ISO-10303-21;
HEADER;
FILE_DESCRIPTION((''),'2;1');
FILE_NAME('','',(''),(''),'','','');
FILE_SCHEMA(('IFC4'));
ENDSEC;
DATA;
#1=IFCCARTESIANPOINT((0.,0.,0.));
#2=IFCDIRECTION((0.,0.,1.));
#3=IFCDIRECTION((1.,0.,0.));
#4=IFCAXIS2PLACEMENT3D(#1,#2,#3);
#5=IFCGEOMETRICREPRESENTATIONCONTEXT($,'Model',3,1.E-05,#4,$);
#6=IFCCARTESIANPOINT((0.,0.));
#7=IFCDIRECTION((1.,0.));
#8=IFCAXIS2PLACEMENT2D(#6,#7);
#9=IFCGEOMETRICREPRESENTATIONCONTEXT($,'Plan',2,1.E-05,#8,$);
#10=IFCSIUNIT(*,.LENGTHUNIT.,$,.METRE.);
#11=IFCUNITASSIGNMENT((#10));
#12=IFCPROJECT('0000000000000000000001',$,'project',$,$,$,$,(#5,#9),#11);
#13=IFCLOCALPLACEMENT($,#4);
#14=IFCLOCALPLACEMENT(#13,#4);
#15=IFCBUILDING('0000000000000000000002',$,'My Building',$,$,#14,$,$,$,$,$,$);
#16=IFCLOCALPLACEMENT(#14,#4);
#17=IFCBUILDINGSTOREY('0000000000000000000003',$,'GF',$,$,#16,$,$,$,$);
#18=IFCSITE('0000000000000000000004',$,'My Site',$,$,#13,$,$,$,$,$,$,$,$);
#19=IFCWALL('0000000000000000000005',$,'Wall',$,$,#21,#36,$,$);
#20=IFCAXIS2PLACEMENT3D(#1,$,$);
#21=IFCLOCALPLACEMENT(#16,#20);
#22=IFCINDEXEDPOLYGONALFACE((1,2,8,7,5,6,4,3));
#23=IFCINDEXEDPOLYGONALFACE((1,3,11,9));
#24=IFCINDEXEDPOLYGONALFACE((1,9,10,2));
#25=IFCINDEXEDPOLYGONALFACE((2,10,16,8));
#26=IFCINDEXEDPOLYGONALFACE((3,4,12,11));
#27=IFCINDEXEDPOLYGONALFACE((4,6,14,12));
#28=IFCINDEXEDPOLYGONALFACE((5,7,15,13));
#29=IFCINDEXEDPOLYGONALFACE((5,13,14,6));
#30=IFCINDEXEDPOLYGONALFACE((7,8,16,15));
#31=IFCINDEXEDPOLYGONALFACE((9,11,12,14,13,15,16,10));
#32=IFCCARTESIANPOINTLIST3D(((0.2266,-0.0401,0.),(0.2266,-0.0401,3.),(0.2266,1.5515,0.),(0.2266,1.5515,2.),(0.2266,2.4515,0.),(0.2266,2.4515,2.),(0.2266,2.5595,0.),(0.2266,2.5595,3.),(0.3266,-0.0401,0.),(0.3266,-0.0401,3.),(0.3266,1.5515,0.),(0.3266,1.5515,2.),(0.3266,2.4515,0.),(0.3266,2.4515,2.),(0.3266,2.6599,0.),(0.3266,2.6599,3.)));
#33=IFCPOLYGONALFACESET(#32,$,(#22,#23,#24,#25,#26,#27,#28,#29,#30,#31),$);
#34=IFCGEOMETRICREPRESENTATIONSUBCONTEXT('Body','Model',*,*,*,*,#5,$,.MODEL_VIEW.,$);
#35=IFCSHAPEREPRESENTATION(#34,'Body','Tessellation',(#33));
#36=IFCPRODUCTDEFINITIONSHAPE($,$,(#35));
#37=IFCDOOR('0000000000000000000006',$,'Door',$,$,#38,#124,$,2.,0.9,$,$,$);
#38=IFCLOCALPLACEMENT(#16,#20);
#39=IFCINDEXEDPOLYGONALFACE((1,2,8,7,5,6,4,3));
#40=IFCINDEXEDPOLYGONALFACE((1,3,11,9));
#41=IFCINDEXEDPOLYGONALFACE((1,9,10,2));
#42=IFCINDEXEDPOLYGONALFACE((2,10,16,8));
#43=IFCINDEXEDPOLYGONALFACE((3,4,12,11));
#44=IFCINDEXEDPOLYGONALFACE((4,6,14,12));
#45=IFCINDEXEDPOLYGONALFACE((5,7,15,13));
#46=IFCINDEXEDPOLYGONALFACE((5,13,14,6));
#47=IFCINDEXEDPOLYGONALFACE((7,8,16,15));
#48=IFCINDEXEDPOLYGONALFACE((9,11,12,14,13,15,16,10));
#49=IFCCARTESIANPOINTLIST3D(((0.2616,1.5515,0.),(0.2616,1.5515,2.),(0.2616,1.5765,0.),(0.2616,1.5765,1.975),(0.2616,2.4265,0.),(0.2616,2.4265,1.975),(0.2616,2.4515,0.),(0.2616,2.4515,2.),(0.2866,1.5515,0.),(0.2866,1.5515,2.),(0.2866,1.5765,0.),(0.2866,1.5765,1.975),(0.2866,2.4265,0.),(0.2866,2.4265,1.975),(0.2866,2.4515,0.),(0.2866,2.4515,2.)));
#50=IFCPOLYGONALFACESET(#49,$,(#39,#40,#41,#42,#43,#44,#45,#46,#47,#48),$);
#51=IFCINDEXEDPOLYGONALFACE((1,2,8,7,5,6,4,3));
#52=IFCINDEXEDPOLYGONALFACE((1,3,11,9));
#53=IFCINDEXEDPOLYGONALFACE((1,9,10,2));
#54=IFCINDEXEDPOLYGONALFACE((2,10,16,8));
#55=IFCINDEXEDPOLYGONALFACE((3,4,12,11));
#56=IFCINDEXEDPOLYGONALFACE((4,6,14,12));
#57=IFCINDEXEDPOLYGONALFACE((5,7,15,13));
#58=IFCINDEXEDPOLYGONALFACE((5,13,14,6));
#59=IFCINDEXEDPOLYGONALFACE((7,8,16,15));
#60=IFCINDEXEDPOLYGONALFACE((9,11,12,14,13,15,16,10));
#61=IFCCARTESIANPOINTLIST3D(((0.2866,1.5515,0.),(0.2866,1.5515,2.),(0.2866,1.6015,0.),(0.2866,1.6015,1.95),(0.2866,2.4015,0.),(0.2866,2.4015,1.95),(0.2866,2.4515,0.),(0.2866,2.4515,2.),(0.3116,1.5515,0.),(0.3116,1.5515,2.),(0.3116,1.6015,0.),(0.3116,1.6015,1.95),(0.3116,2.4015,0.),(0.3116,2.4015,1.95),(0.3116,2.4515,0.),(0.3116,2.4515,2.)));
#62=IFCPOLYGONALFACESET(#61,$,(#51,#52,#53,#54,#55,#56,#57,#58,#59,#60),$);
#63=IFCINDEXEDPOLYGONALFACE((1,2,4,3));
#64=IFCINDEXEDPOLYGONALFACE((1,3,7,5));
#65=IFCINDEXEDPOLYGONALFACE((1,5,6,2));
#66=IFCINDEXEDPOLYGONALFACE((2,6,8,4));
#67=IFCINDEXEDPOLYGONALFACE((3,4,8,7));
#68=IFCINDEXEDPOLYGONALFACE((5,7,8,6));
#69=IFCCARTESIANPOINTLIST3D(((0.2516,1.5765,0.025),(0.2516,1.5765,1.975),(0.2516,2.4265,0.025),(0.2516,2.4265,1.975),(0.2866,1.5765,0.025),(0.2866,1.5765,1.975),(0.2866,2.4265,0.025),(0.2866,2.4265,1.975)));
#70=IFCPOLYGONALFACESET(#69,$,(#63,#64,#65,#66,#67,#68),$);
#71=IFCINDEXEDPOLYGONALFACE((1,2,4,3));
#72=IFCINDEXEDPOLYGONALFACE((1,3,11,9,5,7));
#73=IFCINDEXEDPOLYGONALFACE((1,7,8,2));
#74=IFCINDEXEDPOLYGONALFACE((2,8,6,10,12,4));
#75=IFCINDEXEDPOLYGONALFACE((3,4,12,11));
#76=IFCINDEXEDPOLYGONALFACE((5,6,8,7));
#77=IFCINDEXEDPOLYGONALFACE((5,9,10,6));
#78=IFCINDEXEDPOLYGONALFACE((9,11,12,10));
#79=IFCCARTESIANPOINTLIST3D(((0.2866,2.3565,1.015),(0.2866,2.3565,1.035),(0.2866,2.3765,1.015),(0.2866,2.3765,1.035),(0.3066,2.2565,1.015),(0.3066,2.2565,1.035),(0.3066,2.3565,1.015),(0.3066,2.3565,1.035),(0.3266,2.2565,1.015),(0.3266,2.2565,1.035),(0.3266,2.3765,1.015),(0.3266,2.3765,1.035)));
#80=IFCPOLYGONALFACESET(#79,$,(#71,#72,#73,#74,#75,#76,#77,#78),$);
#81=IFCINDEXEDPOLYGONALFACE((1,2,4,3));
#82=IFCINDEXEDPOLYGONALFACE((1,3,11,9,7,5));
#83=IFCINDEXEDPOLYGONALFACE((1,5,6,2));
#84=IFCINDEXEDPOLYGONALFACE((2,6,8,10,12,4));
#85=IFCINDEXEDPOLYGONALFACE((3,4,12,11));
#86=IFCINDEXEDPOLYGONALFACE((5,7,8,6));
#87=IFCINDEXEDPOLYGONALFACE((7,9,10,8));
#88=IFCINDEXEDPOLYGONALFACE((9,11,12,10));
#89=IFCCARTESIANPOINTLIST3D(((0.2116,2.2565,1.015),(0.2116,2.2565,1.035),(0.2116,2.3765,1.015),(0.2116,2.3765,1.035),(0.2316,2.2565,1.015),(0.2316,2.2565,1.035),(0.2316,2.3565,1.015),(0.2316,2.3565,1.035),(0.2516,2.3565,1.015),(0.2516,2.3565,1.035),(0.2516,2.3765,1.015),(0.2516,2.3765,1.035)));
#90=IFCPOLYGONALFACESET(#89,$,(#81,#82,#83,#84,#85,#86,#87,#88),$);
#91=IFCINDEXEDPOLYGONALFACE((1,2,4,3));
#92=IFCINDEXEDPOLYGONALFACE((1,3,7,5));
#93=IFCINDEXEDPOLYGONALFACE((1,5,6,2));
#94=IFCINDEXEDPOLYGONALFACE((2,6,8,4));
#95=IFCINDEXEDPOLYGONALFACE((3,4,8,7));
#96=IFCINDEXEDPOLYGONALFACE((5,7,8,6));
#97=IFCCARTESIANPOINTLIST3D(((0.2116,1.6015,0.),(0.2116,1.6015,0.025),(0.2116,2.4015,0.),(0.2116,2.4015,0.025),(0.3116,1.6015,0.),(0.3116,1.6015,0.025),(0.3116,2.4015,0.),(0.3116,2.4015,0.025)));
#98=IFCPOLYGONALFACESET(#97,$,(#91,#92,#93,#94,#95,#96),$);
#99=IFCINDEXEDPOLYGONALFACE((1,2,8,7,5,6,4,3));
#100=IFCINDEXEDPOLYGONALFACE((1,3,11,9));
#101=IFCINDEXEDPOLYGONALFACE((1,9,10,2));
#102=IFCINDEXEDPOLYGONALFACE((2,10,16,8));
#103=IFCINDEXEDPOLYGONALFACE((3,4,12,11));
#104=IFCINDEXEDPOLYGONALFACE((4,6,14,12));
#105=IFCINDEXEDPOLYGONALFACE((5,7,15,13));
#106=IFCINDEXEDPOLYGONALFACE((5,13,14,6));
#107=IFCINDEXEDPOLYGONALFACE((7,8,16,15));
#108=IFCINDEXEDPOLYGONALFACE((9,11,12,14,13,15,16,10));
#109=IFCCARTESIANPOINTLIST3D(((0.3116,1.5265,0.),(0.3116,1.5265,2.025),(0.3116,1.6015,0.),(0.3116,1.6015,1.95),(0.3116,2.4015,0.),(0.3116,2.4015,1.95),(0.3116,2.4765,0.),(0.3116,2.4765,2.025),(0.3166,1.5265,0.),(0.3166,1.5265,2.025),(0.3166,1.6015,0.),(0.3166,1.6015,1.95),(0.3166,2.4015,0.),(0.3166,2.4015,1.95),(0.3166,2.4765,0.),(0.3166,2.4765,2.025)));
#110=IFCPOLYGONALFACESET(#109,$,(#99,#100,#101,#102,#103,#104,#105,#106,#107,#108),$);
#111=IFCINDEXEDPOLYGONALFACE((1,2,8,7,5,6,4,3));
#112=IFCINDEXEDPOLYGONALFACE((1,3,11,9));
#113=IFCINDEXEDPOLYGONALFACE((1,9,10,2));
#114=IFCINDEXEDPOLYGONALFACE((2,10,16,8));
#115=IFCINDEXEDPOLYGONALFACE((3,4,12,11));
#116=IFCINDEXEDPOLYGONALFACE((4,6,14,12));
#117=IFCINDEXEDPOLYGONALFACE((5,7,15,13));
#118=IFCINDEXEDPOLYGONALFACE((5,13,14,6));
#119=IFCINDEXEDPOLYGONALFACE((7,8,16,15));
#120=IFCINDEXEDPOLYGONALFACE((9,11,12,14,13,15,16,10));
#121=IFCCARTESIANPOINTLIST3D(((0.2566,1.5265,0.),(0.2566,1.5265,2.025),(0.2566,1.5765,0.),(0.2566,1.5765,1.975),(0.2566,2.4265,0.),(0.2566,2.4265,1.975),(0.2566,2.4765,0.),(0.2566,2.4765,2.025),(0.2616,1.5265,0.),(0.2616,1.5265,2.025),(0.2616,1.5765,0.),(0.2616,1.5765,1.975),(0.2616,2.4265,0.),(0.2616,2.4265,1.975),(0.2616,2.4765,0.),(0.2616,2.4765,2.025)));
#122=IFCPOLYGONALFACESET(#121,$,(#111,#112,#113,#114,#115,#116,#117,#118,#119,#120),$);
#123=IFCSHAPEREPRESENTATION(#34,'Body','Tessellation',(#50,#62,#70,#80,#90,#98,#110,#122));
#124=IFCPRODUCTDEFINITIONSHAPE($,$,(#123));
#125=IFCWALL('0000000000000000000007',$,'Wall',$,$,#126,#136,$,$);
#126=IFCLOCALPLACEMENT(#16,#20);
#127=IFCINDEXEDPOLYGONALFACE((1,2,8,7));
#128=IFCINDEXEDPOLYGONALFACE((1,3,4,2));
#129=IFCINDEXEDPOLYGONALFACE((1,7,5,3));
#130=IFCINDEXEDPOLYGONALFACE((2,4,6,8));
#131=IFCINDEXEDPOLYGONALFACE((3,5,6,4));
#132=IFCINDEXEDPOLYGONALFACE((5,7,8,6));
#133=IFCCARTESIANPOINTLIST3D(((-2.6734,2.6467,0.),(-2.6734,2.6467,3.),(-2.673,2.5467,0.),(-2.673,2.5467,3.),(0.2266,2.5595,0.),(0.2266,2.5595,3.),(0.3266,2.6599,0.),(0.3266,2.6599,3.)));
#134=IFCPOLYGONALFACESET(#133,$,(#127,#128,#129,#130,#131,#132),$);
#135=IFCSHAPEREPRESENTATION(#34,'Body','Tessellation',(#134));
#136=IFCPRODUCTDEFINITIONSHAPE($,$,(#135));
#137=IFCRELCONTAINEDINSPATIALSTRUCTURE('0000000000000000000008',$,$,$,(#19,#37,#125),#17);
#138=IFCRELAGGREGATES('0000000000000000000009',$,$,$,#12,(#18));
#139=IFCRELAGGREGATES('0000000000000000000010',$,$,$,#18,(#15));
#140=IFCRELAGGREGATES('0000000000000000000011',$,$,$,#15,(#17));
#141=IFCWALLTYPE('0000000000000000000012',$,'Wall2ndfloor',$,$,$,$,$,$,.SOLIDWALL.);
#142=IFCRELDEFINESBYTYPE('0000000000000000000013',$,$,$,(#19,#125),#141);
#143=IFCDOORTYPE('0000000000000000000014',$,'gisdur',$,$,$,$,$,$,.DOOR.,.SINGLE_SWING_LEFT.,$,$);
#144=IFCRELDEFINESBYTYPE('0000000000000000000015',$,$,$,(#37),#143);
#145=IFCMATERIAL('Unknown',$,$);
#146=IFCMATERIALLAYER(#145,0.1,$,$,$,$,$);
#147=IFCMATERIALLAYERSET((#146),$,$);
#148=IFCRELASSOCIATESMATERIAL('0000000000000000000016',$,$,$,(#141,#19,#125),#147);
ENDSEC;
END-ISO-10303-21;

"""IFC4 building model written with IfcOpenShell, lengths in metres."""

from ifc_helpers import new_model, entity, si_unit, frame, origin_with_axes, origin_2d_with_axis, place, context, subcontext, project, spatial, line, indexed_curve, outline, extrude, shape, source, transform, mapped, material, layer, layer_set, layer_usage, type_object, type_shapes, element, fill, save


model = new_model("IFC4")

# Units and contexts
model_context = context("Model", 3, precision=1e-05, world=origin_with_axes())
plan_context = context("Plan", 2, precision=1e-05, world=origin_2d_with_axis())
body_context_1 = subcontext(model_context, "Body", "Model", "MODEL_VIEW")
body_context_2 = subcontext(plan_context, "Body", "Plan", "PLAN_VIEW")
ifc_project = project(units=[si_unit("LENGTHUNIT", "METRE")], contexts=[model_context, plan_context])

# Site, building, storey
site_placement = place(None, origin_with_axes())
site = spatial("IfcSite", under=ifc_project, at=site_placement, Name="My Site")
building_placement = place(site_placement, origin_with_axes())
building = spatial("IfcBuilding", under=site, at=building_placement, Name="My Building")
storey_placement = place(building_placement, origin_with_axes())
storey = spatial("IfcBuildingStorey", under=building, at=storey_placement, Name="GF")

# Shared definitions
ifc_material = material(Name="Unknown")

# Shared definitions
ifc_layer_1 = layer(ifc_material, 0.1)
ifc_layer_set_1 = layer_set([ifc_layer_1])
wall_type = type_object("IfcWallType", Name="Wall2ndfloor", PredefinedType="SOLIDWALL", material=ifc_layer_set_1)

# Wall, opening, door
ifc_layer_usage_1 = layer_usage(ifc_layer_set_1, "AXIS2", "POSITIVE", 0.0)
wall_1_placement = place(storey_placement, frame((0.3266, -0.0401, 0.0), z_axis=(0.0, 0.0, 1.0), x_axis=(0.0, 1.0, 0.0)))
wall_1 = element("IfcWall", 1, at=wall_1_placement, inside=storey, type_object=wall_type, material=ifc_layer_usage_1, Name="Wall", context=body_context_1, shape_type="SweptSolid", body=[
    extrude(outline(indexed_curve([(0.0, 0.0), (0.0, 0.1), (2.5996, 0.1), (2.7, 0.0)], segments=[line(1, 2, 3, 4, 1)])), origin_with_axes(), (0.0, 0.0, 1.0), 3.0),
])
shared_shape_1 = source(origin_with_axes(), body_context_1, "Body", "SweptSolid", [
    extrude(outline(indexed_curve([(0.0, 0.0), (0.9, 0.0), (0.9, 2.0), (0.0, 2.0)], segments=[line(1, 2, 3, 4, 1)])), frame((0.0, -0.6, 0.0), z_axis=(0.0, -1.0, 0.0), x_axis=(1.0, 0.0, 0.0)), (0.0, 0.0, -1.0), 1.2),
])
opening_1_placement = place(wall_1_placement, frame((1.5916, 0.015, 0.0), z_axis=(0.0, 0.0, 1.0), x_axis=(1.0, 0.0, 0.0)))
opening_1 = element("IfcOpeningElement", 2, at=opening_1_placement, cuts=wall_1, PredefinedType="OPENING", context=body_context_1, shape_type="MappedRepresentation", body=[
    mapped(shared_shape_1, transform((0.0, 0.0, 0.0), x_axis=(1.0, 0.0, 0.0), y_axis=(0.0, 1.0, 0.0), z_axis=(0.0, 0.0, 1.0), scale=1.0)),
])
door_type_1 = type_object("IfcDoorType", Name="gisdur", OperationType="SINGLE_SWING_LEFT", PredefinedType="DOOR")
shared_shape_2 = source(origin_with_axes(), body_context_1, "Body", "SweptSolid", [
    extrude(outline(indexed_curve([(0.0, 0.0), (0.0, 2.0), (0.9, 2.0), (0.9, 0.0), (0.875, 0.0), (0.875, 1.975), (0.025, 1.975), (0.025, 0.0)], segments=[line(1, 2, 3, 4, 5, 6, 7, 8, 1)])), frame((0.0, 0.025, 0.0), z_axis=(0.0, -1.0, 0.0), x_axis=(1.0, 0.0, 0.0)), (0.0, 0.0, -1.0), 0.025),
    extrude(outline(indexed_curve([(0.0, 0.0), (0.0, 2.0), (0.9, 2.0), (0.9, 0.0), (0.85, 0.0), (0.85, 1.95), (0.05, 1.95), (0.05, 0.0)], segments=[line(1, 2, 3, 4, 5, 6, 7, 8, 1)])), frame((0.0, 0.0, 0.0), z_axis=(0.0, -1.0, 0.0), x_axis=(1.0, 0.0, 0.0)), (0.0, 0.0, -1.0), 0.025),
    extrude(outline(indexed_curve([(0.0, 0.0), (0.85, 0.0), (0.85, 0.035), (0.0, 0.035)], segments=[line(1, 2, 3, 4, 1)])), frame((0.025, 0.025, 0.025), z_axis=(0.0, 0.0, 1.0), x_axis=(1.0, 0.0, 0.0)), (0.0, 0.0, 1.0), 1.95),
    extrude(outline(indexed_curve([(0.0, 0.0), (0.0, -0.04), (-0.12, -0.04), (-0.12, -0.02), (-0.02, -0.02), (-0.02, 0.0)], segments=[line(1, 2, 3, 4, 5, 6, 1)])), frame((0.825, 0.025, 1.015), z_axis=(0.0, 0.0, 1.0), x_axis=(1.0, 0.0, 0.0)), (0.0, 0.0, 1.0), 0.02),
    extrude(outline(indexed_curve([(0.0, 0.0), (0.0, 0.04), (-0.12, 0.04), (-0.12, 0.02), (-0.02, 0.02), (-0.02, 0.0)], segments=[line(1, 2, 3, 4, 5, 6, 1)])), frame((0.825, 0.06, 1.015), z_axis=(0.0, 0.0, 1.0), x_axis=(1.0, 0.0, 0.0)), (0.0, 0.0, 1.0), 0.02),
    extrude(outline(indexed_curve([(0.0, 0.0), (0.8, 0.0), (0.8, 0.1), (0.0, 0.1)], segments=[line(1, 2, 3, 4, 1)])), frame((0.05, 0.0, 0.0), z_axis=(0.0, 0.0, 1.0), x_axis=(1.0, 0.0, 0.0)), (0.0, 0.0, 1.0), 0.025),
    extrude(outline(indexed_curve([(0.0, 0.0), (0.0, 2.025), (0.95, 2.025), (0.95, 0.0), (0.875, 0.0), (0.875, 1.95), (0.075, 1.95), (0.075, 0.0)], segments=[line(1, 2, 3, 4, 5, 6, 7, 8, 1)])), frame((-0.025, -0.005, 0.0), z_axis=(0.0, -1.0, 0.0), x_axis=(1.0, 0.0, 0.0)), (0.0, 0.0, -1.0), 0.005),
    extrude(outline(indexed_curve([(0.0, 0.0), (0.0, 2.025), (0.95, 2.025), (0.95, 0.0), (0.9, 0.0), (0.9, 1.975), (0.05, 1.975), (0.05, 0.0)], segments=[line(1, 2, 3, 4, 5, 6, 7, 8, 1)])), frame((-0.025, 0.05, 0.0), z_axis=(0.0, -1.0, 0.0), x_axis=(1.0, 0.0, 0.0)), (0.0, 0.0, -1.0), 0.005),
])
shared_shape_3 = source(origin_with_axes(), body_context_2, "Body", "Curve2D", [
    entity("IfcIndexedPolyCurve", entity("IfcCartesianPointList2D", [[0.0, 0.0], [0.0, 0.05], [0.025, 0.05], [0.025, 0.025], [0.05, 0.025], [0.05, 0.0]]), [entity("IfcLineIndex", [1, 2, 3, 4, 5, 6, 1])]),
    entity("IfcIndexedPolyCurve", entity("IfcCartesianPointList2D", [[0.9, 0.0], [0.9, 0.05], [0.875, 0.05], [0.875, 0.025], [0.85, 0.025], [0.85, 0.0]]), [entity("IfcLineIndex", [1, 2, 3, 4, 5, 6, 1])]),
    entity("IfcTrimmedCurve", entity("IfcEllipse", entity("IfcAxis2Placement2D", entity("IfcCartesianPoint", [0.06, 0.05]), entity("IfcDirection", [1.0, 0.0])), 0.815, 0.85), [entity("IfcCartesianPoint", [0.875, 0.05])], [entity("IfcCartesianPoint", [0.06, 0.9])], True, "CARTESIAN"),
    entity("IfcIndexedPolyCurve", entity("IfcCartesianPointList2D", [[0.025, 0.05], [0.06, 0.05], [0.06, 0.9], [0.025, 0.9]]), [entity("IfcLineIndex", [1, 2, 3, 4, 1])]),
])
type_shapes(door_type_1, [shared_shape_2, shared_shape_3])
door_1_placement = place(opening_1_placement, frame((0.0, 0.0, 0.0), z_axis=(0.0, 0.0, 1.0), x_axis=(1.0, 0.0, 0.0)))
door_1 = element("IfcDoor", 3, at=door_1_placement, inside=storey, type_object=door_type_1, Name="Door", OverallHeight=2.0, OverallWidth=0.9, shapes=[
    shape(body_context_1, "Body", "MappedRepresentation", [mapped(shared_shape_2, transform((0.0, 0.0, 0.0), x_axis=(1.0, 0.0, 0.0), y_axis=(0.0, 1.0, 0.0), z_axis=(0.0, 0.0, 1.0), scale=1.0))]),
    shape(body_context_2, "Body", "MappedRepresentation", [mapped(shared_shape_3, transform((0.0, 0.0, 0.0), x_axis=(1.0, 0.0, 0.0), y_axis=(0.0, 1.0, 0.0), z_axis=(0.0, 0.0, 1.0), scale=1.0))]),
])
fill(opening_1, door_1)

# Wall
ifc_layer_usage_2 = layer_usage(ifc_layer_set_1, "AXIS2", "POSITIVE", 0.0)
wall_2_placement = place(storey_placement, frame((0.3266, 2.6599, 0.0), z_axis=(0.0, 0.0, 1.0), x_axis=(-0.99999, -0.004387, 0.0)))
element("IfcWall", 4, at=wall_2_placement, inside=storey, type_object=wall_type, material=ifc_layer_usage_2, Name="Wall", context=body_context_1, shape_type="SweptSolid", body=[
    extrude(outline(indexed_curve([(0.0, 0.0), (0.1004, 0.1), (3.0, 0.1), (3.0, 0.0)], segments=[line(1, 2, 3, 4, 1)])), origin_with_axes(), (0.0, 0.0, 1.0), 3.0),
])

save(model, "model.ifc")
